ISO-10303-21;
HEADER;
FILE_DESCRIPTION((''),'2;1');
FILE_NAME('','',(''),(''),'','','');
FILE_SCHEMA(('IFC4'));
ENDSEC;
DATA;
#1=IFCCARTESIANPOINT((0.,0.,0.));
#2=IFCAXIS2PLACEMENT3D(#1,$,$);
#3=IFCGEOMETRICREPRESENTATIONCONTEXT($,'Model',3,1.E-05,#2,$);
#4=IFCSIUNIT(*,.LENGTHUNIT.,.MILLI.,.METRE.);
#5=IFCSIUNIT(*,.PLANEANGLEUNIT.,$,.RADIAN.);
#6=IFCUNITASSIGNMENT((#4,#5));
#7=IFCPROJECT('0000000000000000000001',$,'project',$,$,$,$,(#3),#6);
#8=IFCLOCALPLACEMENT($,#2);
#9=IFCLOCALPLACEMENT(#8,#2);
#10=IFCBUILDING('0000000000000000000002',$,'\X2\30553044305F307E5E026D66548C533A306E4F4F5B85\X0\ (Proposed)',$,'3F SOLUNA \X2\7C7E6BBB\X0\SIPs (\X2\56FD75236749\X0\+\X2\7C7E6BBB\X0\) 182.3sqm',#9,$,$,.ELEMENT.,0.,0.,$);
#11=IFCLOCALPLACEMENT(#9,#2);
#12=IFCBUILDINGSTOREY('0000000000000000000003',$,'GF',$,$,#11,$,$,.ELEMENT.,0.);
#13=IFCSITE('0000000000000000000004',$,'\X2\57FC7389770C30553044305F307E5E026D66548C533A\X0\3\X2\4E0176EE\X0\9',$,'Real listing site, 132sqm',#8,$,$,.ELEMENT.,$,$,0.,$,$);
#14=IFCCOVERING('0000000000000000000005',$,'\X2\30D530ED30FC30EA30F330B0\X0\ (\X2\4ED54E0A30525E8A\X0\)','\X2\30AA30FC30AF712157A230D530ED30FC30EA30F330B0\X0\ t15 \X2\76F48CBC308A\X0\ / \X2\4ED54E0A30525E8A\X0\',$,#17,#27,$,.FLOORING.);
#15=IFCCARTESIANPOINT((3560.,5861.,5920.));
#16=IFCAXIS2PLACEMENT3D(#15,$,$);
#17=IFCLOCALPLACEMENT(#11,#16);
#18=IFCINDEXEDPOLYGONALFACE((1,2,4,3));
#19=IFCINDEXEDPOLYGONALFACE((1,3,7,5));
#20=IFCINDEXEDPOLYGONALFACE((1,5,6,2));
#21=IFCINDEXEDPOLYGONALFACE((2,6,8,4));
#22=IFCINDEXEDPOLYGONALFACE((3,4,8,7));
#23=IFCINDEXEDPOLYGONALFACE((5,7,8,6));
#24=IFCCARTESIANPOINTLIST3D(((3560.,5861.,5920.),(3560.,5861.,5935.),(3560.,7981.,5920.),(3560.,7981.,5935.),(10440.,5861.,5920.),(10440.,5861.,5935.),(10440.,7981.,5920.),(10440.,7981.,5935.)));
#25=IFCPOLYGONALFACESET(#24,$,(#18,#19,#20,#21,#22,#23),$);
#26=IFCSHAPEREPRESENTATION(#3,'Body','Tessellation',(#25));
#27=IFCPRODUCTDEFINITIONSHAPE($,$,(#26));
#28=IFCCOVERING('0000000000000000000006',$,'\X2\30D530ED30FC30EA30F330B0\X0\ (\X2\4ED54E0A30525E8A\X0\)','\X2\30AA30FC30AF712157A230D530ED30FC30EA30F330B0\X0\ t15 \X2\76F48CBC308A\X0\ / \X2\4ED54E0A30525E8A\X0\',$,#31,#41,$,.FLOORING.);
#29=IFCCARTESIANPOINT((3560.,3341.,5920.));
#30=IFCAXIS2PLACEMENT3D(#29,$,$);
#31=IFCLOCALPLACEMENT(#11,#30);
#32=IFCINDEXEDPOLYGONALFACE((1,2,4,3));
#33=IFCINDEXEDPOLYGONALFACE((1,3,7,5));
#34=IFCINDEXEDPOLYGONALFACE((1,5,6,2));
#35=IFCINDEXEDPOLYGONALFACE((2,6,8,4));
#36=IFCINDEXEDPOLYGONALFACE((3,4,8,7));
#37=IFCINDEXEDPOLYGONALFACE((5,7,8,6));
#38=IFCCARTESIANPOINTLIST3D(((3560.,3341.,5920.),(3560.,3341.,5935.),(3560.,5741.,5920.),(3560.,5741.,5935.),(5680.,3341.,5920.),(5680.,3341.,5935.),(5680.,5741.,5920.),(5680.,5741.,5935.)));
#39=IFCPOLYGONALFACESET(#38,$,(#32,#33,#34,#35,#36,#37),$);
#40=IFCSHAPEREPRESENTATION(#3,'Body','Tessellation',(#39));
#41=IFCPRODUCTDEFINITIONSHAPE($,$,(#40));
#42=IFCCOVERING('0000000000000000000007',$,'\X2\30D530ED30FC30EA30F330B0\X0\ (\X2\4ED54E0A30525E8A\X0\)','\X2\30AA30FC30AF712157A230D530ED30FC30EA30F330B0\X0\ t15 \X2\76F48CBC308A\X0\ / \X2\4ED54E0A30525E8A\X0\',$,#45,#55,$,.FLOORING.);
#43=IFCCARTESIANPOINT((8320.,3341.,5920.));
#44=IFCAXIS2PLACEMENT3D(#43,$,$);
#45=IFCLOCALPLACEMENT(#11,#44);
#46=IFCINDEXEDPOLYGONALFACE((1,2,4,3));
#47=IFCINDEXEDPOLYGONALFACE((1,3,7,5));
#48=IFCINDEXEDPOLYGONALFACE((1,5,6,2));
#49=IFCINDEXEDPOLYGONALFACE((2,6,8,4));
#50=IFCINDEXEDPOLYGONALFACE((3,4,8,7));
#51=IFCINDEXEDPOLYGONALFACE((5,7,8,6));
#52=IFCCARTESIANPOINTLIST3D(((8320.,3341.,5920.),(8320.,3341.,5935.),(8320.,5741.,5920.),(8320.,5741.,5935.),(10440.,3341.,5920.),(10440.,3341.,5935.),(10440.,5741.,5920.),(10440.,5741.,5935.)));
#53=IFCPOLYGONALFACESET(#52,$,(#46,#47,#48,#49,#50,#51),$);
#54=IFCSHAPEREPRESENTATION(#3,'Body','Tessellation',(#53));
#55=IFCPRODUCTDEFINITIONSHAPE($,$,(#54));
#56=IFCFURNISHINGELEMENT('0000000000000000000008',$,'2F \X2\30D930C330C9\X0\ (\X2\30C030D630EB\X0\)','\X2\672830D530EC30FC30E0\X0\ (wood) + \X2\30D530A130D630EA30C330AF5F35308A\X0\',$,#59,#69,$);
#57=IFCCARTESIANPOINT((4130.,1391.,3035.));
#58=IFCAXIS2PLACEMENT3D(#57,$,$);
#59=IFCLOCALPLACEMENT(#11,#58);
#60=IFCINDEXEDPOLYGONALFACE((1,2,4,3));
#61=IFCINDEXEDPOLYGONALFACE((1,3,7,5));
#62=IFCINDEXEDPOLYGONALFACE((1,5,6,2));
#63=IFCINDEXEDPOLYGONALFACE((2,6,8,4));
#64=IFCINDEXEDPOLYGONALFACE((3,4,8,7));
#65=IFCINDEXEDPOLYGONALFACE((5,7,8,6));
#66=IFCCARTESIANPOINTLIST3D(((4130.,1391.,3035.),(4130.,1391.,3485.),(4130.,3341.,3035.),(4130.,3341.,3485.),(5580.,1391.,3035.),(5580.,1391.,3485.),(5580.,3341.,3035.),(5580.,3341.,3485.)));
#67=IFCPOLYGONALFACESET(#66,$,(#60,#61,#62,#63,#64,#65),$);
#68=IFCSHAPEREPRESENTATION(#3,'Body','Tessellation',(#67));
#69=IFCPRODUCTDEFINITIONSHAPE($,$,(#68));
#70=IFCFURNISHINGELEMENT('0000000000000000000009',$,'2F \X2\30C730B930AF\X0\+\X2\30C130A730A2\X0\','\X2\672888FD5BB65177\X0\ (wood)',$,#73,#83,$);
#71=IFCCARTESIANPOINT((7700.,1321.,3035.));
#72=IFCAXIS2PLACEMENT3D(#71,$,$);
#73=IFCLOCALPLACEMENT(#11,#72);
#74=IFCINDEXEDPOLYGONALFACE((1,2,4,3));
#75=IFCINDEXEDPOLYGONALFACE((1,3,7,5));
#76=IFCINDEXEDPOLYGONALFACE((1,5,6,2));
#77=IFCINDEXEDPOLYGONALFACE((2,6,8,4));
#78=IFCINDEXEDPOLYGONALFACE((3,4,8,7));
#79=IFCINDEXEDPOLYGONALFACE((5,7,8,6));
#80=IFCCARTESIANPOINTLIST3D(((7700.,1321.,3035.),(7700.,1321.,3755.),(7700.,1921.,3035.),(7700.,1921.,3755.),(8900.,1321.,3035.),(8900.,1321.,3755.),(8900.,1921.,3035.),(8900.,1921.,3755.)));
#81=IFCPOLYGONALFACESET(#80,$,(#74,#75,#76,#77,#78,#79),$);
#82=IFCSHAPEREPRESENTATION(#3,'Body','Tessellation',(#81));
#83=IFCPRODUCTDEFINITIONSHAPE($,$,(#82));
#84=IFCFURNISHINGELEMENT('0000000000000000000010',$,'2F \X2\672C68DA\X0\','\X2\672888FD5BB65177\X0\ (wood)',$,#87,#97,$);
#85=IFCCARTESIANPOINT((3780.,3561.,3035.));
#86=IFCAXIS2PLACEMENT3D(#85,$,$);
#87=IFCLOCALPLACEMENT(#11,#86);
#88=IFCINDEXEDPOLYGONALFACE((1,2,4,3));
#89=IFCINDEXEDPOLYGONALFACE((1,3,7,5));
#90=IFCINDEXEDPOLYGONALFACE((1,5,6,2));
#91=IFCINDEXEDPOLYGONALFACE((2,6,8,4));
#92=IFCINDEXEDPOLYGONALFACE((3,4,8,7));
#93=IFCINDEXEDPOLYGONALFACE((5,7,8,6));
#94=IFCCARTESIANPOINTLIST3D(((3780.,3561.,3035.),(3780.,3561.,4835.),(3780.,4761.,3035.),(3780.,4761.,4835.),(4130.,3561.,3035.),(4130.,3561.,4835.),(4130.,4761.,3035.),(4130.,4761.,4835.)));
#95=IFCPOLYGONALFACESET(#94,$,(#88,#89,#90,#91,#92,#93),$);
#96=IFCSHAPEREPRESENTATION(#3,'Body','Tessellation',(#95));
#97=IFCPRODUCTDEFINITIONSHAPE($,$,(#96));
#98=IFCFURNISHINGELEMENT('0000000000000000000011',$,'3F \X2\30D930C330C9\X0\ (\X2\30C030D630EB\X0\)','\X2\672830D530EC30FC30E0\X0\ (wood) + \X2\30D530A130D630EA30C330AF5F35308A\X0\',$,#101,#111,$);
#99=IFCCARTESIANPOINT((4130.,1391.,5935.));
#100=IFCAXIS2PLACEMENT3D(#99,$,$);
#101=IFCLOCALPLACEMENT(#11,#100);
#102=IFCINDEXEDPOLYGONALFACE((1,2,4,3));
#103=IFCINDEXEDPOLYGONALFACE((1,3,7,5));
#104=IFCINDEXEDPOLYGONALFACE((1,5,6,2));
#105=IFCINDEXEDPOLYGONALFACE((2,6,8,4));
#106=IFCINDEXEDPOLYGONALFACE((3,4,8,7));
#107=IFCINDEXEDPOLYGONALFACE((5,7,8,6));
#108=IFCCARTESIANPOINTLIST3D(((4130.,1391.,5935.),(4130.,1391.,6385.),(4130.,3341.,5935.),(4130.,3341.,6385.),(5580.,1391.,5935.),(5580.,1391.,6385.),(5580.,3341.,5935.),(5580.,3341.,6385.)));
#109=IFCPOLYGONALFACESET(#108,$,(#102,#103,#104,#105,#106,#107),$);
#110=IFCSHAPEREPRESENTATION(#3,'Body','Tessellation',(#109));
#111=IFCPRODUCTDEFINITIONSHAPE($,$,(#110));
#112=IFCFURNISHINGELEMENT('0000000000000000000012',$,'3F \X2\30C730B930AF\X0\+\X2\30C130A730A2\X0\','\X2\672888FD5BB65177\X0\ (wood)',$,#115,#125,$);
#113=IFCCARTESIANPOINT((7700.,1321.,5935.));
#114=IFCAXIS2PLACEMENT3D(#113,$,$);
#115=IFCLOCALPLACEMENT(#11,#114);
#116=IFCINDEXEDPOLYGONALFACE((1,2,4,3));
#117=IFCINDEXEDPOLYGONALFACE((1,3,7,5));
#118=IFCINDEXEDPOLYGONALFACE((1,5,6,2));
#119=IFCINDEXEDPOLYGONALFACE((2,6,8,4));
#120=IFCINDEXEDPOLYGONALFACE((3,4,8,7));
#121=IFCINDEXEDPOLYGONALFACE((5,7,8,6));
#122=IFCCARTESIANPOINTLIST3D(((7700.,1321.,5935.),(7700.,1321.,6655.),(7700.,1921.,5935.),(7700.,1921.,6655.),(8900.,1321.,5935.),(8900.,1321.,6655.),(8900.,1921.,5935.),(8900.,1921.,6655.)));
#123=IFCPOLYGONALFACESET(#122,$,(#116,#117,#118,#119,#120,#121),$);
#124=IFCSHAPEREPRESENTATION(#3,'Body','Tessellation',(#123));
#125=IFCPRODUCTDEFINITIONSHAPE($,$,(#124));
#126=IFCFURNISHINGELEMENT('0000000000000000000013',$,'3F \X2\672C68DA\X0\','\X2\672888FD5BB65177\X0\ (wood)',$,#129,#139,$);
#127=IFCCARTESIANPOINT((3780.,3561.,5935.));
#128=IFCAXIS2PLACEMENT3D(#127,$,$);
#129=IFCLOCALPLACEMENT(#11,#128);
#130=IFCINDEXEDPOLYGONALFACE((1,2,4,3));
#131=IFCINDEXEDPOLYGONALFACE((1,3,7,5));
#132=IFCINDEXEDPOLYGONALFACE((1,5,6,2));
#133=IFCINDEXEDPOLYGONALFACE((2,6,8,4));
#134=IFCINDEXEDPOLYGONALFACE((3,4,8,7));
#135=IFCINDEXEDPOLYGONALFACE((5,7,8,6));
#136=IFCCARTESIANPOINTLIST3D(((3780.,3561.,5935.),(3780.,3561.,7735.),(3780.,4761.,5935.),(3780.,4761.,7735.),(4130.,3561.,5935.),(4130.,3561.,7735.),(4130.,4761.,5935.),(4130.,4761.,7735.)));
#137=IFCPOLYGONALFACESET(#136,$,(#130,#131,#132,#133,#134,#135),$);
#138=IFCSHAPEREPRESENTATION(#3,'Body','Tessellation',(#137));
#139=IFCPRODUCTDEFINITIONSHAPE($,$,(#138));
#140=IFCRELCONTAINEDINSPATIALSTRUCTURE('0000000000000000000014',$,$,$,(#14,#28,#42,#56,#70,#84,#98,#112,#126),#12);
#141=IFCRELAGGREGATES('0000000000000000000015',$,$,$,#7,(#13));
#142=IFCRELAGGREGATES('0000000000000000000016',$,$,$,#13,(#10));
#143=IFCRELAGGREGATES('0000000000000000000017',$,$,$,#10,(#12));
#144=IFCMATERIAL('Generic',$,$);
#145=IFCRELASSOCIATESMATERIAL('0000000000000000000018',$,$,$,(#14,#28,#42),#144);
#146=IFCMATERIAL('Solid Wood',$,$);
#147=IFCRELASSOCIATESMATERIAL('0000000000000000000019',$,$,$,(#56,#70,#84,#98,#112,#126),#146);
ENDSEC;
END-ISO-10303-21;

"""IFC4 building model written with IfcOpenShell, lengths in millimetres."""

from ifc_helpers import new_model, si_unit, frame, frame_2d, origin, place, context, project, spatial, rectangle, extrude, material, element, save


model = new_model("IFC4")

# Units and contexts
model_context = context("Model", 3, precision=1e-05, world=origin())
ifc_project = project(units=[si_unit("LENGTHUNIT", "METRE", prefix="MILLI"), si_unit("PLANEANGLEUNIT", "RADIAN")], contexts=[model_context])

# Site, building, storey
site_placement = place(None, origin())
site = spatial("IfcSite", under=ifc_project, at=site_placement, Name="埼玉県さいたま市浦和区3丁目9", ObjectType="Real listing site, 132sqm", CompositionType="ELEMENT", RefElevation=0.0)
building_placement = place(site_placement, origin())
building = spatial("IfcBuilding", under=site, at=building_placement, Name="さいたま市浦和区の住宅 (Proposed)", ObjectType="3F SOLUNA 籾殻SIPs (国産杉+籾殻) 182.3sqm", CompositionType="ELEMENT", ElevationOfRefHeight=0.0, ElevationOfTerrain=0.0)
storey_placement = place(building_placement, origin())
storey = spatial("IfcBuildingStorey", under=building, at=storey_placement, Name="GF", CompositionType="ELEMENT", Elevation=0.0)

# Shared definitions
ifc_material_1 = material(Name="Solid Wood")

# Shared definitions
ifc_material_2 = material(Name="Generic")

# Coverings
covering_1_placement = place(storey_placement, frame((3560.0, 5861.0, 5920.0)))
element("IfcCovering", 1, at=covering_1_placement, inside=storey, material=ifc_material_2, Name="フローリング (仕上げ床)", Description="オーク無垢フローリング t15 直貼り / 仕上げ床", PredefinedType="FLOORING", context=model_context, shape_type="SweptSolid", body=[
    extrude(rectangle(XDim=6880.0, YDim=2120.0, at=frame_2d((3440.0, 1060.0))), frame((3560.0, 5861.0, 5920.0)), (0.0, 0.0, 1.0), 15.0),
])
covering_2_placement = place(storey_placement, frame((3560.0, 3341.0, 5920.0)))
element("IfcCovering", 2, at=covering_2_placement, inside=storey, material=ifc_material_2, Name="フローリング (仕上げ床)", Description="オーク無垢フローリング t15 直貼り / 仕上げ床", PredefinedType="FLOORING", context=model_context, shape_type="SweptSolid", body=[
    extrude(rectangle(XDim=2120.0, YDim=2400.0, at=frame_2d((1060.0, 1200.0))), frame((3560.0, 3341.0, 5920.0)), (0.0, 0.0, 1.0), 15.0),
])
covering_3_placement = place(storey_placement, frame((8320.0, 3341.0, 5920.0)))
element("IfcCovering", 3, at=covering_3_placement, inside=storey, material=ifc_material_2, Name="フローリング (仕上げ床)", Description="オーク無垢フローリング t15 直貼り / 仕上げ床", PredefinedType="FLOORING", context=model_context, shape_type="SweptSolid", body=[
    extrude(rectangle(XDim=2120.0, YDim=2400.0, at=frame_2d((1060.0, 1200.0))), frame((8320.0, 3341.0, 5920.0)), (0.0, 0.0, 1.0), 15.0),
])

# Furnishing elements
furnishing_1_placement = place(storey_placement, frame((4130.0, 1391.0, 3035.0)))
element("IfcFurnishingElement", 4, at=furnishing_1_placement, inside=storey, material=ifc_material_1, Name="2F ベッド (ダブル)", Description="木フレーム (wood) + ファブリック張り", context=model_context, shape_type="SweptSolid", body=[
    extrude(rectangle(XDim=1450.0, YDim=1950.0, at=frame_2d((725.0, 975.0))), frame((4130.0, 1391.0, 3035.0)), (0.0, 0.0, 1.0), 450.0),
])
furnishing_2_placement = place(storey_placement, frame((7700.0, 1321.0, 3035.0)))
element("IfcFurnishingElement", 5, at=furnishing_2_placement, inside=storey, material=ifc_material_1, Name="2F デスク+チェア", Description="木製家具 (wood)", context=model_context, shape_type="SweptSolid", body=[
    extrude(rectangle(XDim=1200.0, YDim=600.0, at=frame_2d((600.0, 300.0))), frame((7700.0, 1321.0, 3035.0)), (0.0, 0.0, 1.0), 720.0),
])
furnishing_3_placement = place(storey_placement, frame((3780.0, 3561.0, 3035.0)))
element("IfcFurnishingElement", 6, at=furnishing_3_placement, inside=storey, material=ifc_material_1, Name="2F 本棚", Description="木製家具 (wood)", context=model_context, shape_type="SweptSolid", body=[
    extrude(rectangle(XDim=350.0, YDim=1200.0, at=frame_2d((175.0, 600.0))), frame((3780.0, 3561.0, 3035.0)), (0.0, 0.0, 1.0), 1800.0),
])
furnishing_4_placement = place(storey_placement, frame((4130.0, 1391.0, 5935.0)))
element("IfcFurnishingElement", 7, at=furnishing_4_placement, inside=storey, material=ifc_material_1, Name="3F ベッド (ダブル)", Description="木フレーム (wood) + ファブリック張り", context=model_context, shape_type="SweptSolid", body=[
    extrude(rectangle(XDim=1450.0, YDim=1950.0, at=frame_2d((725.0, 975.0))), frame((4130.0, 1391.0, 5935.0)), (0.0, 0.0, 1.0), 450.0),
])
furnishing_5_placement = place(storey_placement, frame((7700.0, 1321.0, 5935.0)))
element("IfcFurnishingElement", 8, at=furnishing_5_placement, inside=storey, material=ifc_material_1, Name="3F デスク+チェア", Description="木製家具 (wood)", context=model_context, shape_type="SweptSolid", body=[
    extrude(rectangle(XDim=1200.0, YDim=600.0, at=frame_2d((600.0, 300.0))), frame((7700.0, 1321.0, 5935.0)), (0.0, 0.0, 1.0), 720.0),
])
furnishing_6_placement = place(storey_placement, frame((3780.0, 3561.0, 5935.0)))
element("IfcFurnishingElement", 9, at=furnishing_6_placement, inside=storey, material=ifc_material_1, Name="3F 本棚", Description="木製家具 (wood)", context=model_context, shape_type="SweptSolid", body=[
    extrude(rectangle(XDim=350.0, YDim=1200.0, at=frame_2d((175.0, 600.0))), frame((3780.0, 3561.0, 5935.0)), (0.0, 0.0, 1.0), 1800.0),
])

save(model, "model.ifc")
